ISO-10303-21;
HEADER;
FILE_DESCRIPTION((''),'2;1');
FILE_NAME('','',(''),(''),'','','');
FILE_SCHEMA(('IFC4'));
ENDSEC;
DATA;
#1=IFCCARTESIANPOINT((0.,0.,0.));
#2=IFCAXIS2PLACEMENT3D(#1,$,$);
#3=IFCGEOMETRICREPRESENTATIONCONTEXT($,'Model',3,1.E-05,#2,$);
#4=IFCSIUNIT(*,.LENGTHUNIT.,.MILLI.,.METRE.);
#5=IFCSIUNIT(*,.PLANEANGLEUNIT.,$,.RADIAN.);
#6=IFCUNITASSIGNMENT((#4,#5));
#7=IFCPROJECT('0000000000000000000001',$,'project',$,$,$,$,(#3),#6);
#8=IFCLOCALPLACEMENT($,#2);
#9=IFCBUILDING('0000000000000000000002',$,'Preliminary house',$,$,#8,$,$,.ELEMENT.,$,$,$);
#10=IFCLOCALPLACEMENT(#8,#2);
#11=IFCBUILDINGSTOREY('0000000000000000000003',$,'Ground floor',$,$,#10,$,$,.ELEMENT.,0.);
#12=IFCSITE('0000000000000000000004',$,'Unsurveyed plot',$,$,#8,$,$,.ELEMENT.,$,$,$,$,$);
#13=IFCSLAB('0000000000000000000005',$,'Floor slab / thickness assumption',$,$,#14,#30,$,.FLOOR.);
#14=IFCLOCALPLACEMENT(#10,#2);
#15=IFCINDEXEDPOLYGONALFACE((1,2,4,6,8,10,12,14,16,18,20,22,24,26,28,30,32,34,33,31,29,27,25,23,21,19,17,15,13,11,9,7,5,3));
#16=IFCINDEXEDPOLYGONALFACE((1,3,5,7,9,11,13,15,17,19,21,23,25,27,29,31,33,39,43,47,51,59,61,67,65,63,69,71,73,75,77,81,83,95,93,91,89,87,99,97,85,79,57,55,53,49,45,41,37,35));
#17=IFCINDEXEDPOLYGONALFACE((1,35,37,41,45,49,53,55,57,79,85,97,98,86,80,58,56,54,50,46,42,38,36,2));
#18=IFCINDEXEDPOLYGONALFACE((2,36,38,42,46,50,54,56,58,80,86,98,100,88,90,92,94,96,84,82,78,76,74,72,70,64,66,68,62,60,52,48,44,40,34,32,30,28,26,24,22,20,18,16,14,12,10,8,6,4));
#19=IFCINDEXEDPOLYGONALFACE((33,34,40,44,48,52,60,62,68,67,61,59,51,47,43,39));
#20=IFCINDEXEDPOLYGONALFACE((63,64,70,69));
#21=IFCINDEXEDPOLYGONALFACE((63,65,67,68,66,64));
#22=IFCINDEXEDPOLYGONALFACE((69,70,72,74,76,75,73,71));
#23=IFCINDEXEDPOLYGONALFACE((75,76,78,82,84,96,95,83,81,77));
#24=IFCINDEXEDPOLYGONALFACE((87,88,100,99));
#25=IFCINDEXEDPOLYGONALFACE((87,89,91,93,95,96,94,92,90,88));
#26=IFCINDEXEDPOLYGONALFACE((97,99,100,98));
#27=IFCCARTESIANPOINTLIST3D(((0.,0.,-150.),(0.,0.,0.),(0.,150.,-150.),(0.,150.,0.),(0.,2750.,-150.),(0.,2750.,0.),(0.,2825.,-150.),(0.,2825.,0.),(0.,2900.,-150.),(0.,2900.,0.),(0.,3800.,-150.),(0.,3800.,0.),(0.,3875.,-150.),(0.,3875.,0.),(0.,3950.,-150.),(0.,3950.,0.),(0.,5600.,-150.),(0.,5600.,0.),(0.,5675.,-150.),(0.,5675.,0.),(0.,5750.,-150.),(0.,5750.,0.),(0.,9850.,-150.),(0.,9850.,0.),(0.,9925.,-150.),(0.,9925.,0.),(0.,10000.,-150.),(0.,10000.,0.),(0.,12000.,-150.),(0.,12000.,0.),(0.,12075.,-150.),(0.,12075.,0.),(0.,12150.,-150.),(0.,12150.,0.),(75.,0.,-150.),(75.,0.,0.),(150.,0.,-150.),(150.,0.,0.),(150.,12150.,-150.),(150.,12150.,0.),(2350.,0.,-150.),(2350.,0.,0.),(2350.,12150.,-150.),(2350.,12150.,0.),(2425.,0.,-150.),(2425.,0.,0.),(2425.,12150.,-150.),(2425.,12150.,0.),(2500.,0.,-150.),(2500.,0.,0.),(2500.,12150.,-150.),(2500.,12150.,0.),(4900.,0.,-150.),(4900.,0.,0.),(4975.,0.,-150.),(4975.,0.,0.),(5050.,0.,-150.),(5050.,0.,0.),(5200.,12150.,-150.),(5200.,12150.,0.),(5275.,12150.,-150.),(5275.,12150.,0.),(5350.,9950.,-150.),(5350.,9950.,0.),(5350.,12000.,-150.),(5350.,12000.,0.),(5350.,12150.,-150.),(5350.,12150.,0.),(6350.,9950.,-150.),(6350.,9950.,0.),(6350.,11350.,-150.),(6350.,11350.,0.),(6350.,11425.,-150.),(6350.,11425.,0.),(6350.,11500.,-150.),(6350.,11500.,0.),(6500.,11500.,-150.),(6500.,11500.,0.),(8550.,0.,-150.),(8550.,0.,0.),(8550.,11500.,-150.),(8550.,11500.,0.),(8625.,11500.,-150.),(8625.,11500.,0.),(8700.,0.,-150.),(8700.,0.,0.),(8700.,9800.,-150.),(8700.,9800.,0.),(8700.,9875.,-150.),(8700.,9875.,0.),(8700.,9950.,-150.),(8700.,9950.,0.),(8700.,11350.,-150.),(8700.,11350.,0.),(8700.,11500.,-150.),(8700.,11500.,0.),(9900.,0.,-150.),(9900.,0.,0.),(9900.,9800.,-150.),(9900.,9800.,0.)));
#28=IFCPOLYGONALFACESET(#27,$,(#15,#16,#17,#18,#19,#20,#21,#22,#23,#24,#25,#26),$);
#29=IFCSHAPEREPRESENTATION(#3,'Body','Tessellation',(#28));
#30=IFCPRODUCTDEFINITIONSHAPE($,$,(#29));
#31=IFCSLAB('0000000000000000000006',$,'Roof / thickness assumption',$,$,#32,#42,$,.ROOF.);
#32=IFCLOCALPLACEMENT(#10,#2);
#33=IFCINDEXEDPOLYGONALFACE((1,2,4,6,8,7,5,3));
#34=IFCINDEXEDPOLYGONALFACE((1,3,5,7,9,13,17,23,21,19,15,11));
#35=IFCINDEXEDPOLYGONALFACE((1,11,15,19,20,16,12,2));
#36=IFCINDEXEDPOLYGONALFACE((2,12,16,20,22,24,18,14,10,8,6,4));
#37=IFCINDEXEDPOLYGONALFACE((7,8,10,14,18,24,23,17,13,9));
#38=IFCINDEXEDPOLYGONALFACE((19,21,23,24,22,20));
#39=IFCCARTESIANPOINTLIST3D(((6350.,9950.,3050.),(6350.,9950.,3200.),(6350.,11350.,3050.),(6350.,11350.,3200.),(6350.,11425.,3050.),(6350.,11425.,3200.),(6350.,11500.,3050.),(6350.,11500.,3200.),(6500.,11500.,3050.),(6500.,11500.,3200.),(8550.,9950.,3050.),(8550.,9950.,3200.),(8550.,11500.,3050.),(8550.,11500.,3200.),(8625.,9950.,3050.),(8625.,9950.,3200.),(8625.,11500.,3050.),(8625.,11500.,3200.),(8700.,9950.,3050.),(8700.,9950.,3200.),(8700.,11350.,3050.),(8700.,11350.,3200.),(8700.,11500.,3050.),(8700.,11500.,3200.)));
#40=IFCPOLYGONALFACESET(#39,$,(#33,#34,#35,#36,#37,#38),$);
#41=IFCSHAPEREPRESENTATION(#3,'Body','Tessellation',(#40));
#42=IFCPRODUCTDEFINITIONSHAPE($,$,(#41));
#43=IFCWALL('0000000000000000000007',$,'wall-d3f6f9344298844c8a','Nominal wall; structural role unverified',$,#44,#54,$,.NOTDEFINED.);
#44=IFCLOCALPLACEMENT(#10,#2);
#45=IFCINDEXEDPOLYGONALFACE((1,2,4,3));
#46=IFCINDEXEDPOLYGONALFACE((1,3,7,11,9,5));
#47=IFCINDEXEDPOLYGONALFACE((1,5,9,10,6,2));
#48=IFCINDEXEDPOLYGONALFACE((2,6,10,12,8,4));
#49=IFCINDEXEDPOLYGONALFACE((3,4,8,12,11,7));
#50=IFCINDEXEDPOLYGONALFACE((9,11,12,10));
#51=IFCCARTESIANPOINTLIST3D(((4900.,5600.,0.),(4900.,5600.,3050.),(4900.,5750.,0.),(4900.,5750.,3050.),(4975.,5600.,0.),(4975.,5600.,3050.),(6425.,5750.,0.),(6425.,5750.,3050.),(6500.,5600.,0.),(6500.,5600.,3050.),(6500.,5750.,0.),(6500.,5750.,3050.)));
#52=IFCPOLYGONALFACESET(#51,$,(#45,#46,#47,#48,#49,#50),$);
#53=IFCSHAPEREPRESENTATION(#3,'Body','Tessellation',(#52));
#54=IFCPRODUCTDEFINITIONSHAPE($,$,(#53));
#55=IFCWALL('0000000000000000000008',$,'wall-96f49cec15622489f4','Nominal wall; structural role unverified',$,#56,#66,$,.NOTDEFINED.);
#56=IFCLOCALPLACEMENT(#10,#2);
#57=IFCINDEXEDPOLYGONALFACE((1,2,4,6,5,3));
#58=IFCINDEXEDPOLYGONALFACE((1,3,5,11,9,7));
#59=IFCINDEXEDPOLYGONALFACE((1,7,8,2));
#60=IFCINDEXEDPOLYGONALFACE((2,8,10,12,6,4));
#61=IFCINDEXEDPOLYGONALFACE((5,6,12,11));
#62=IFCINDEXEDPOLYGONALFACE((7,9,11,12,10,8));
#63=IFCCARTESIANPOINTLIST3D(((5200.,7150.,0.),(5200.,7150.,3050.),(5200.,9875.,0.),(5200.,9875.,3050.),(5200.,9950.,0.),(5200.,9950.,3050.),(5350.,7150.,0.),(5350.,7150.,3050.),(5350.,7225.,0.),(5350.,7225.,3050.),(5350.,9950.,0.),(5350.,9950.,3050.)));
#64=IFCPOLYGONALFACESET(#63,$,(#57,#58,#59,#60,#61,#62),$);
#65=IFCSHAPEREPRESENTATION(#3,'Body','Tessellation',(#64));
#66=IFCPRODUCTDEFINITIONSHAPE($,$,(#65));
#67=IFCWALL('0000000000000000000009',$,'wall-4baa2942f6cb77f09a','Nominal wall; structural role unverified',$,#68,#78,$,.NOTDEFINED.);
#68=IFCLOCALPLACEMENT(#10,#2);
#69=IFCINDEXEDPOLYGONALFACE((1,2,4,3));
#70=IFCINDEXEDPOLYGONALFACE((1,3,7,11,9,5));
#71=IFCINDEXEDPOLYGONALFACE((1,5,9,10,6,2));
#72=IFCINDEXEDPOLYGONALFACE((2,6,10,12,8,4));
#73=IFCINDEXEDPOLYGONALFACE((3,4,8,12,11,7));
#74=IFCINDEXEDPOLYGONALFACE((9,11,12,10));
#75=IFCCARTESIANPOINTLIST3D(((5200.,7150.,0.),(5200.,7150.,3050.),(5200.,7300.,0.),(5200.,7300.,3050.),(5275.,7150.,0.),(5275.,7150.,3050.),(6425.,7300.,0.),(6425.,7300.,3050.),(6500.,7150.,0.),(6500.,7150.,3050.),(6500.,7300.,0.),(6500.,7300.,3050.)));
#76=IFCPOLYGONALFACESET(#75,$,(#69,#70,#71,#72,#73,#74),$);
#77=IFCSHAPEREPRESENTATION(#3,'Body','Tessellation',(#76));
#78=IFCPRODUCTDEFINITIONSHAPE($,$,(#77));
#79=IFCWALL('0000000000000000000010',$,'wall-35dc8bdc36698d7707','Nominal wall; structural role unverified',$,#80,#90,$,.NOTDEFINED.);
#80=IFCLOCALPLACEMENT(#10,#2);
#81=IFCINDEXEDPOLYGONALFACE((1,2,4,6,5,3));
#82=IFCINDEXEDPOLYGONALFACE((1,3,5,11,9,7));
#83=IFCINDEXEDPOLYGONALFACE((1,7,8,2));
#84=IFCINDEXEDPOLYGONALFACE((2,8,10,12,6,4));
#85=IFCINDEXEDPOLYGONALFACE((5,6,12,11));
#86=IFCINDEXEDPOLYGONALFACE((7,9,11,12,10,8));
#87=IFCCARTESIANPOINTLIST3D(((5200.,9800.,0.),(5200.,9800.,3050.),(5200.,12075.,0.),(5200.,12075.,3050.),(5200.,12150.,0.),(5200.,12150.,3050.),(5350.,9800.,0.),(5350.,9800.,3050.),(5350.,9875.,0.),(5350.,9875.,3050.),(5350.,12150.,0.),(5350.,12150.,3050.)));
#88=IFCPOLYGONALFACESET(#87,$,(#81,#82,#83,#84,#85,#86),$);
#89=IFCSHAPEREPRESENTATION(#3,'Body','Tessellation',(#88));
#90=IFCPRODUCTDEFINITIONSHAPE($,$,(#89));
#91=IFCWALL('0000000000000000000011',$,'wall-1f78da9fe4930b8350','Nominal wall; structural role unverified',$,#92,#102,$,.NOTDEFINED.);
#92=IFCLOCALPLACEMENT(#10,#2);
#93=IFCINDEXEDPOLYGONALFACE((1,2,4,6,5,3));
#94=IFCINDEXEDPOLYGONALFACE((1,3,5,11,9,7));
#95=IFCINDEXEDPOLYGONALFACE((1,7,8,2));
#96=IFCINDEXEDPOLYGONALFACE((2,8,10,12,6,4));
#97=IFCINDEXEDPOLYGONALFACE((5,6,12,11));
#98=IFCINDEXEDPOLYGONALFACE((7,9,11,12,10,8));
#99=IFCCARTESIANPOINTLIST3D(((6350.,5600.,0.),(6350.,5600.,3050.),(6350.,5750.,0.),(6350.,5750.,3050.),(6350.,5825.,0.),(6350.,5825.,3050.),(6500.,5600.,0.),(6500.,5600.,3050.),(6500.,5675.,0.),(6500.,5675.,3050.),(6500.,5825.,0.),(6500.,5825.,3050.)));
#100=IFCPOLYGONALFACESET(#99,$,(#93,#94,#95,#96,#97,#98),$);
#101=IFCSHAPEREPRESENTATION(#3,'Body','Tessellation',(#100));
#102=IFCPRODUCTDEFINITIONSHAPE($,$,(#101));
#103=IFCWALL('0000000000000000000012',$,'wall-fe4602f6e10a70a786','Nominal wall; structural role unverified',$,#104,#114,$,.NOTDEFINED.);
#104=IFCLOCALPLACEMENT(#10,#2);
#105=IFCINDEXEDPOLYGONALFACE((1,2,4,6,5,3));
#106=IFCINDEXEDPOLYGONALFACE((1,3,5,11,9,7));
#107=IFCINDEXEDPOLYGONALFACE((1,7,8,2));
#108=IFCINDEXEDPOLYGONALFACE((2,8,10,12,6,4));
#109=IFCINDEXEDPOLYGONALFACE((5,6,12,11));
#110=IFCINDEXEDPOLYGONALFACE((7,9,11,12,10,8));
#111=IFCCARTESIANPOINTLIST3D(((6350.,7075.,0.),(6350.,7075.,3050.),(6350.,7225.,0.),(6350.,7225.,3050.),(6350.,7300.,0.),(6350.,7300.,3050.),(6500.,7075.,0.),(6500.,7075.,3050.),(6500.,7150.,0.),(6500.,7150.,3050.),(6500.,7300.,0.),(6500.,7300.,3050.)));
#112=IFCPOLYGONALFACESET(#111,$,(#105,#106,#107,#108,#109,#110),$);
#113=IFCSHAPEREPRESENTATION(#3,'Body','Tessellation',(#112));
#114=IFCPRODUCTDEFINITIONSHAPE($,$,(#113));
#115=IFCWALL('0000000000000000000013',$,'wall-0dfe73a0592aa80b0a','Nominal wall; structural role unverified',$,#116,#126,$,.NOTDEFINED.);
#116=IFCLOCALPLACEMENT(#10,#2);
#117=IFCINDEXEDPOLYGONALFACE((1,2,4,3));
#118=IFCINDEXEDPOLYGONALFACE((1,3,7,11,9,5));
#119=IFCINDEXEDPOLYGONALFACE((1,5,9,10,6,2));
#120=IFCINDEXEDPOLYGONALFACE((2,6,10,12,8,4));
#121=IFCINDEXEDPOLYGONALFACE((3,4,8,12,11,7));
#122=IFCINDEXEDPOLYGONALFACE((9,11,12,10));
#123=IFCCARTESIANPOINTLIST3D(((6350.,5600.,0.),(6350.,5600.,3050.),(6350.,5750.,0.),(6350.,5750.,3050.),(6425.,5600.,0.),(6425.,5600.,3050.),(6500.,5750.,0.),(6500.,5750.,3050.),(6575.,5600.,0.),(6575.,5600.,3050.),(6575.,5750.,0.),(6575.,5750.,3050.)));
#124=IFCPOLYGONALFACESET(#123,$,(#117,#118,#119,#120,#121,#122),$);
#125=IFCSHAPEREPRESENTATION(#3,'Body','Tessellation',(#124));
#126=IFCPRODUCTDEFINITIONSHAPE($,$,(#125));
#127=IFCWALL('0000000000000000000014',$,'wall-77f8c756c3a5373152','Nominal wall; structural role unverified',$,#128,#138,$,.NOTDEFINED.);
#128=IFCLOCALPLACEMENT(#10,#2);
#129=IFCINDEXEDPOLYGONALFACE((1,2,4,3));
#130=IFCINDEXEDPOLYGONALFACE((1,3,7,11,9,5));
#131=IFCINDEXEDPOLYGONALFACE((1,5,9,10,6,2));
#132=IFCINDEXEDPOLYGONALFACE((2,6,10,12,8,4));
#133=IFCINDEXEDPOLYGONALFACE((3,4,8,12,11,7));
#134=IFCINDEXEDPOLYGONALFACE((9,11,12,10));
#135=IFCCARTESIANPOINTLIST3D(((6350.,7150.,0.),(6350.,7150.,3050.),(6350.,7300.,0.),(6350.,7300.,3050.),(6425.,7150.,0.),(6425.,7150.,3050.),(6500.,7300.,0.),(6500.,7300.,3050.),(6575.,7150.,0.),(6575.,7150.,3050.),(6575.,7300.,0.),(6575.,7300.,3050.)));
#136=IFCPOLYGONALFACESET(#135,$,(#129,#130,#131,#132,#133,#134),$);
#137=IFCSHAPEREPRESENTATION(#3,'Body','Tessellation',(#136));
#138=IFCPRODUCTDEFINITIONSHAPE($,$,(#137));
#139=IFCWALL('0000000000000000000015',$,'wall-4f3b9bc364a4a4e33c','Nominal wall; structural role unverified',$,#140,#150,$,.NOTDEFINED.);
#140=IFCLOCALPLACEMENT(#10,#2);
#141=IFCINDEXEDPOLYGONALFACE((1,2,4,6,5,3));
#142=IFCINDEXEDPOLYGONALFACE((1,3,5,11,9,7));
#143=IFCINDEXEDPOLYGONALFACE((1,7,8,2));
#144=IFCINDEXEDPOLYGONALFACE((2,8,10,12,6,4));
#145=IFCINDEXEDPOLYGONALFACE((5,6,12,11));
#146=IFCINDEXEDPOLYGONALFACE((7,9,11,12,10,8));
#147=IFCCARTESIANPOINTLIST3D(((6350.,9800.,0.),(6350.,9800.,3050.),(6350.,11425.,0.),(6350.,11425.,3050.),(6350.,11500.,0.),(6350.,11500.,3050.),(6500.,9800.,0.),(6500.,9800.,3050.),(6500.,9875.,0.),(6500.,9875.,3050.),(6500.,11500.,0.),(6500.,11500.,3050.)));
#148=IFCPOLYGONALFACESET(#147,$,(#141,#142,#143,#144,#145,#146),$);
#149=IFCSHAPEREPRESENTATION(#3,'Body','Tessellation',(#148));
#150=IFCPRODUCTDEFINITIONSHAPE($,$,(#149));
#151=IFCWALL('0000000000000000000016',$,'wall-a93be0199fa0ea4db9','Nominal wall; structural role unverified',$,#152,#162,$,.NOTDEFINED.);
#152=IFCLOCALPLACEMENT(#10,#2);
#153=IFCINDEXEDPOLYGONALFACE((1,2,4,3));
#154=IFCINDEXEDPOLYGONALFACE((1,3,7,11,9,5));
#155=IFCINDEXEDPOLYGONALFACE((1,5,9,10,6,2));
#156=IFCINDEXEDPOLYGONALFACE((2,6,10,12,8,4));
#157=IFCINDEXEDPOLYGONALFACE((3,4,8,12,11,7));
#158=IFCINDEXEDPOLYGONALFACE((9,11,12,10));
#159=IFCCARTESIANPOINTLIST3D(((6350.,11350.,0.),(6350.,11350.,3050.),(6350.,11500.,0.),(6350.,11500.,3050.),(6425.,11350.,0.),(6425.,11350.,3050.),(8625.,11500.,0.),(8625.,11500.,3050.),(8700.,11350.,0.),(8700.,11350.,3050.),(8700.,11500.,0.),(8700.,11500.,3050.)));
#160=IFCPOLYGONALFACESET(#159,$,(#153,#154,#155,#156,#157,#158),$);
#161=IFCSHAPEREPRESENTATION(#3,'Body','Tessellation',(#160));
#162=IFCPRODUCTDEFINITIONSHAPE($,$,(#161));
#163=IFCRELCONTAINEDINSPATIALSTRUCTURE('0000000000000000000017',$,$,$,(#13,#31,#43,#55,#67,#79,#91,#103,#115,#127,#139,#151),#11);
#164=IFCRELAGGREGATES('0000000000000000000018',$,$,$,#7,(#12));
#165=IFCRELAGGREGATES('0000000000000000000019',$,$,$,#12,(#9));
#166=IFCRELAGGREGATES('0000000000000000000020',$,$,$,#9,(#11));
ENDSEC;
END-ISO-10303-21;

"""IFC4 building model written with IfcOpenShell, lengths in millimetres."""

from ifc_helpers import new_model, si_unit, frame, origin, place, context, project, spatial, polyline, outline, extrude, element, save


model = new_model("IFC4")

# Units and contexts
model_context = context("Model", 3, precision=1e-05, world=origin())
ifc_project = project(units=[si_unit("LENGTHUNIT", "METRE", prefix="MILLI"), si_unit("PLANEANGLEUNIT", "RADIAN")], contexts=[model_context])

# Site, building, storey
placement_1 = place(None, origin())
site = spatial("IfcSite", under=ifc_project, at=placement_1, Name="Unsurveyed plot", CompositionType="ELEMENT")
building = spatial("IfcBuilding", under=site, at=placement_1, Name="Preliminary house", CompositionType="ELEMENT")
placement_2 = place(placement_1, origin())
storey = spatial("IfcBuildingStorey", under=building, at=placement_2, Name="Ground floor", CompositionType="ELEMENT", Elevation=0.0)

# Slabs
element("IfcSlab", 1, at=placement_2, inside=storey, Name="Floor slab / thickness assumption", PredefinedType="FLOOR", context=model_context, shape_type="SweptSolid", body=[
    extrude(outline(polyline([(0.0, 0.0), (0.0, 150.0), (0.0, 2750.0), (0.0, 2825.0), (0.0, 2900.0), (0.0, 3800.0), (0.0, 3875.0), (0.0, 3950.0), (0.0, 5600.0), (0.0, 5675.0), (0.0, 5750.0), (0.0, 9850.0), (0.0, 9925.0), (0.0, 10000.0), (0.0, 12000.0), (0.0, 12075.0), (0.0, 12150.0), (150.0, 12150.0), (2350.0, 12150.0), (2425.0, 12150.0), (2500.0, 12150.0), (5200.0, 12150.0), (5275.0, 12150.0), (5350.0, 12150.0), (5350.0, 12000.0), (5350.0, 9950.0), (6350.0, 9950.0), (6350.0, 11350.0), (6350.0, 11425.0), (6350.0, 11500.0), (6500.0, 11500.0), (8550.0, 11500.0), (8625.0, 11500.0), (8700.0, 11500.0), (8700.0, 11350.0), (8700.0, 9950.0), (8700.0, 9875.0), (8700.0, 9800.0), (9900.0, 9800.0), (9900.0, 0.0), (8700.0, 0.0), (8550.0, 0.0), (5050.0, 0.0), (4975.0, 0.0), (4900.0, 0.0), (2500.0, 0.0), (2425.0, 0.0), (2350.0, 0.0), (150.0, 0.0), (75.0, 0.0), (0.0, 0.0)])), frame((0.0, 0.0, -150.0)), (0.0, 0.0, 1.0), 150.0),
])
element("IfcSlab", 2, at=placement_2, inside=storey, Name="Roof / thickness assumption", PredefinedType="ROOF", context=model_context, shape_type="SweptSolid", body=[
    extrude(outline(polyline([(6350.0, 11350.0), (6350.0, 11425.0), (6350.0, 11500.0), (6500.0, 11500.0), (8550.0, 11500.0), (8625.0, 11500.0), (8700.0, 11500.0), (8700.0, 11350.0), (8700.0, 9950.0), (8625.0, 9950.0), (8550.0, 9950.0), (6350.0, 9950.0), (6350.0, 11350.0)])), frame((0.0, 0.0, 3050.0)), (0.0, 0.0, 1.0), 150.0),
])

# Walls
element("IfcWall", 3, at=placement_2, inside=storey, Name="wall-d3f6f9344298844c8a", Description="Nominal wall; structural role unverified", PredefinedType="NOTDEFINED", context=model_context, shape_type="SweptSolid", body=[
    extrude(outline(polyline([(6425.0, 5750.0), (6500.0, 5750.0), (6500.0, 5600.0), (4975.0, 5600.0), (4900.0, 5600.0), (4900.0, 5750.0), (6425.0, 5750.0)])), origin(), (0.0, 0.0, 1.0), 3050.0),
])
element("IfcWall", 4, at=placement_2, inside=storey, Name="wall-96f49cec15622489f4", Description="Nominal wall; structural role unverified", PredefinedType="NOTDEFINED", context=model_context, shape_type="SweptSolid", body=[
    extrude(outline(polyline([(5200.0, 9875.0), (5200.0, 9950.0), (5350.0, 9950.0), (5350.0, 7225.0), (5350.0, 7150.0), (5200.0, 7150.0), (5200.0, 9875.0)])), origin(), (0.0, 0.0, 1.0), 3050.0),
])
element("IfcWall", 5, at=placement_2, inside=storey, Name="wall-4baa2942f6cb77f09a", Description="Nominal wall; structural role unverified", PredefinedType="NOTDEFINED", context=model_context, shape_type="SweptSolid", body=[
    extrude(outline(polyline([(6425.0, 7300.0), (6500.0, 7300.0), (6500.0, 7150.0), (5275.0, 7150.0), (5200.0, 7150.0), (5200.0, 7300.0), (6425.0, 7300.0)])), origin(), (0.0, 0.0, 1.0), 3050.0),
])
element("IfcWall", 6, at=placement_2, inside=storey, Name="wall-35dc8bdc36698d7707", Description="Nominal wall; structural role unverified", PredefinedType="NOTDEFINED", context=model_context, shape_type="SweptSolid", body=[
    extrude(outline(polyline([(5200.0, 12075.0), (5200.0, 12150.0), (5350.0, 12150.0), (5350.0, 9875.0), (5350.0, 9800.0), (5200.0, 9800.0), (5200.0, 12075.0)])), origin(), (0.0, 0.0, 1.0), 3050.0),
])

# Wall
element("IfcWall", 7, at=placement_2, inside=storey, Name="wall-1f78da9fe4930b8350", Description="Nominal wall; structural role unverified", PredefinedType="NOTDEFINED", context=model_context, shape_type="SweptSolid", body=[
    extrude(outline(polyline([(6350.0, 5750.0), (6350.0, 5825.0), (6500.0, 5825.0), (6500.0, 5675.0), (6500.0, 5600.0), (6350.0, 5600.0), (6350.0, 5750.0)])), origin(), (0.0, 0.0, 1.0), 3050.0),
])

# Walls
element("IfcWall", 8, at=placement_2, inside=storey, Name="wall-fe4602f6e10a70a786", Description="Nominal wall; structural role unverified", PredefinedType="NOTDEFINED", context=model_context, shape_type="SweptSolid", body=[
    extrude(outline(polyline([(6350.0, 7225.0), (6350.0, 7300.0), (6500.0, 7300.0), (6500.0, 7150.0), (6500.0, 7075.0), (6350.0, 7075.0), (6350.0, 7225.0)])), origin(), (0.0, 0.0, 1.0), 3050.0),
])
element("IfcWall", 9, at=placement_2, inside=storey, Name="wall-0dfe73a0592aa80b0a", Description="Nominal wall; structural role unverified", PredefinedType="NOTDEFINED", context=model_context, shape_type="SweptSolid", body=[
    extrude(outline(polyline([(6500.0, 5750.0), (6575.0, 5750.0), (6575.0, 5600.0), (6425.0, 5600.0), (6350.0, 5600.0), (6350.0, 5750.0), (6500.0, 5750.0)])), origin(), (0.0, 0.0, 1.0), 3050.0),
])

# Wall
element("IfcWall", 10, at=placement_2, inside=storey, Name="wall-77f8c756c3a5373152", Description="Nominal wall; structural role unverified", PredefinedType="NOTDEFINED", context=model_context, shape_type="SweptSolid", body=[
    extrude(outline(polyline([(6500.0, 7300.0), (6575.0, 7300.0), (6575.0, 7150.0), (6425.0, 7150.0), (6350.0, 7150.0), (6350.0, 7300.0), (6500.0, 7300.0)])), origin(), (0.0, 0.0, 1.0), 3050.0),
])

# Wall
element("IfcWall", 11, at=placement_2, inside=storey, Name="wall-4f3b9bc364a4a4e33c", Description="Nominal wall; structural role unverified", PredefinedType="NOTDEFINED", context=model_context, shape_type="SweptSolid", body=[
    extrude(outline(polyline([(6350.0, 11425.0), (6350.0, 11500.0), (6500.0, 11500.0), (6500.0, 9875.0), (6500.0, 9800.0), (6350.0, 9800.0), (6350.0, 11425.0)])), origin(), (0.0, 0.0, 1.0), 3050.0),
])

# Wall
element("IfcWall", 12, at=placement_2, inside=storey, Name="wall-a93be0199fa0ea4db9", Description="Nominal wall; structural role unverified", PredefinedType="NOTDEFINED", context=model_context, shape_type="SweptSolid", body=[
    extrude(outline(polyline([(8625.0, 11500.0), (8700.0, 11500.0), (8700.0, 11350.0), (6425.0, 11350.0), (6350.0, 11350.0), (6350.0, 11500.0), (8625.0, 11500.0)])), origin(), (0.0, 0.0, 1.0), 3050.0),
])

save(model, "model.ifc")
